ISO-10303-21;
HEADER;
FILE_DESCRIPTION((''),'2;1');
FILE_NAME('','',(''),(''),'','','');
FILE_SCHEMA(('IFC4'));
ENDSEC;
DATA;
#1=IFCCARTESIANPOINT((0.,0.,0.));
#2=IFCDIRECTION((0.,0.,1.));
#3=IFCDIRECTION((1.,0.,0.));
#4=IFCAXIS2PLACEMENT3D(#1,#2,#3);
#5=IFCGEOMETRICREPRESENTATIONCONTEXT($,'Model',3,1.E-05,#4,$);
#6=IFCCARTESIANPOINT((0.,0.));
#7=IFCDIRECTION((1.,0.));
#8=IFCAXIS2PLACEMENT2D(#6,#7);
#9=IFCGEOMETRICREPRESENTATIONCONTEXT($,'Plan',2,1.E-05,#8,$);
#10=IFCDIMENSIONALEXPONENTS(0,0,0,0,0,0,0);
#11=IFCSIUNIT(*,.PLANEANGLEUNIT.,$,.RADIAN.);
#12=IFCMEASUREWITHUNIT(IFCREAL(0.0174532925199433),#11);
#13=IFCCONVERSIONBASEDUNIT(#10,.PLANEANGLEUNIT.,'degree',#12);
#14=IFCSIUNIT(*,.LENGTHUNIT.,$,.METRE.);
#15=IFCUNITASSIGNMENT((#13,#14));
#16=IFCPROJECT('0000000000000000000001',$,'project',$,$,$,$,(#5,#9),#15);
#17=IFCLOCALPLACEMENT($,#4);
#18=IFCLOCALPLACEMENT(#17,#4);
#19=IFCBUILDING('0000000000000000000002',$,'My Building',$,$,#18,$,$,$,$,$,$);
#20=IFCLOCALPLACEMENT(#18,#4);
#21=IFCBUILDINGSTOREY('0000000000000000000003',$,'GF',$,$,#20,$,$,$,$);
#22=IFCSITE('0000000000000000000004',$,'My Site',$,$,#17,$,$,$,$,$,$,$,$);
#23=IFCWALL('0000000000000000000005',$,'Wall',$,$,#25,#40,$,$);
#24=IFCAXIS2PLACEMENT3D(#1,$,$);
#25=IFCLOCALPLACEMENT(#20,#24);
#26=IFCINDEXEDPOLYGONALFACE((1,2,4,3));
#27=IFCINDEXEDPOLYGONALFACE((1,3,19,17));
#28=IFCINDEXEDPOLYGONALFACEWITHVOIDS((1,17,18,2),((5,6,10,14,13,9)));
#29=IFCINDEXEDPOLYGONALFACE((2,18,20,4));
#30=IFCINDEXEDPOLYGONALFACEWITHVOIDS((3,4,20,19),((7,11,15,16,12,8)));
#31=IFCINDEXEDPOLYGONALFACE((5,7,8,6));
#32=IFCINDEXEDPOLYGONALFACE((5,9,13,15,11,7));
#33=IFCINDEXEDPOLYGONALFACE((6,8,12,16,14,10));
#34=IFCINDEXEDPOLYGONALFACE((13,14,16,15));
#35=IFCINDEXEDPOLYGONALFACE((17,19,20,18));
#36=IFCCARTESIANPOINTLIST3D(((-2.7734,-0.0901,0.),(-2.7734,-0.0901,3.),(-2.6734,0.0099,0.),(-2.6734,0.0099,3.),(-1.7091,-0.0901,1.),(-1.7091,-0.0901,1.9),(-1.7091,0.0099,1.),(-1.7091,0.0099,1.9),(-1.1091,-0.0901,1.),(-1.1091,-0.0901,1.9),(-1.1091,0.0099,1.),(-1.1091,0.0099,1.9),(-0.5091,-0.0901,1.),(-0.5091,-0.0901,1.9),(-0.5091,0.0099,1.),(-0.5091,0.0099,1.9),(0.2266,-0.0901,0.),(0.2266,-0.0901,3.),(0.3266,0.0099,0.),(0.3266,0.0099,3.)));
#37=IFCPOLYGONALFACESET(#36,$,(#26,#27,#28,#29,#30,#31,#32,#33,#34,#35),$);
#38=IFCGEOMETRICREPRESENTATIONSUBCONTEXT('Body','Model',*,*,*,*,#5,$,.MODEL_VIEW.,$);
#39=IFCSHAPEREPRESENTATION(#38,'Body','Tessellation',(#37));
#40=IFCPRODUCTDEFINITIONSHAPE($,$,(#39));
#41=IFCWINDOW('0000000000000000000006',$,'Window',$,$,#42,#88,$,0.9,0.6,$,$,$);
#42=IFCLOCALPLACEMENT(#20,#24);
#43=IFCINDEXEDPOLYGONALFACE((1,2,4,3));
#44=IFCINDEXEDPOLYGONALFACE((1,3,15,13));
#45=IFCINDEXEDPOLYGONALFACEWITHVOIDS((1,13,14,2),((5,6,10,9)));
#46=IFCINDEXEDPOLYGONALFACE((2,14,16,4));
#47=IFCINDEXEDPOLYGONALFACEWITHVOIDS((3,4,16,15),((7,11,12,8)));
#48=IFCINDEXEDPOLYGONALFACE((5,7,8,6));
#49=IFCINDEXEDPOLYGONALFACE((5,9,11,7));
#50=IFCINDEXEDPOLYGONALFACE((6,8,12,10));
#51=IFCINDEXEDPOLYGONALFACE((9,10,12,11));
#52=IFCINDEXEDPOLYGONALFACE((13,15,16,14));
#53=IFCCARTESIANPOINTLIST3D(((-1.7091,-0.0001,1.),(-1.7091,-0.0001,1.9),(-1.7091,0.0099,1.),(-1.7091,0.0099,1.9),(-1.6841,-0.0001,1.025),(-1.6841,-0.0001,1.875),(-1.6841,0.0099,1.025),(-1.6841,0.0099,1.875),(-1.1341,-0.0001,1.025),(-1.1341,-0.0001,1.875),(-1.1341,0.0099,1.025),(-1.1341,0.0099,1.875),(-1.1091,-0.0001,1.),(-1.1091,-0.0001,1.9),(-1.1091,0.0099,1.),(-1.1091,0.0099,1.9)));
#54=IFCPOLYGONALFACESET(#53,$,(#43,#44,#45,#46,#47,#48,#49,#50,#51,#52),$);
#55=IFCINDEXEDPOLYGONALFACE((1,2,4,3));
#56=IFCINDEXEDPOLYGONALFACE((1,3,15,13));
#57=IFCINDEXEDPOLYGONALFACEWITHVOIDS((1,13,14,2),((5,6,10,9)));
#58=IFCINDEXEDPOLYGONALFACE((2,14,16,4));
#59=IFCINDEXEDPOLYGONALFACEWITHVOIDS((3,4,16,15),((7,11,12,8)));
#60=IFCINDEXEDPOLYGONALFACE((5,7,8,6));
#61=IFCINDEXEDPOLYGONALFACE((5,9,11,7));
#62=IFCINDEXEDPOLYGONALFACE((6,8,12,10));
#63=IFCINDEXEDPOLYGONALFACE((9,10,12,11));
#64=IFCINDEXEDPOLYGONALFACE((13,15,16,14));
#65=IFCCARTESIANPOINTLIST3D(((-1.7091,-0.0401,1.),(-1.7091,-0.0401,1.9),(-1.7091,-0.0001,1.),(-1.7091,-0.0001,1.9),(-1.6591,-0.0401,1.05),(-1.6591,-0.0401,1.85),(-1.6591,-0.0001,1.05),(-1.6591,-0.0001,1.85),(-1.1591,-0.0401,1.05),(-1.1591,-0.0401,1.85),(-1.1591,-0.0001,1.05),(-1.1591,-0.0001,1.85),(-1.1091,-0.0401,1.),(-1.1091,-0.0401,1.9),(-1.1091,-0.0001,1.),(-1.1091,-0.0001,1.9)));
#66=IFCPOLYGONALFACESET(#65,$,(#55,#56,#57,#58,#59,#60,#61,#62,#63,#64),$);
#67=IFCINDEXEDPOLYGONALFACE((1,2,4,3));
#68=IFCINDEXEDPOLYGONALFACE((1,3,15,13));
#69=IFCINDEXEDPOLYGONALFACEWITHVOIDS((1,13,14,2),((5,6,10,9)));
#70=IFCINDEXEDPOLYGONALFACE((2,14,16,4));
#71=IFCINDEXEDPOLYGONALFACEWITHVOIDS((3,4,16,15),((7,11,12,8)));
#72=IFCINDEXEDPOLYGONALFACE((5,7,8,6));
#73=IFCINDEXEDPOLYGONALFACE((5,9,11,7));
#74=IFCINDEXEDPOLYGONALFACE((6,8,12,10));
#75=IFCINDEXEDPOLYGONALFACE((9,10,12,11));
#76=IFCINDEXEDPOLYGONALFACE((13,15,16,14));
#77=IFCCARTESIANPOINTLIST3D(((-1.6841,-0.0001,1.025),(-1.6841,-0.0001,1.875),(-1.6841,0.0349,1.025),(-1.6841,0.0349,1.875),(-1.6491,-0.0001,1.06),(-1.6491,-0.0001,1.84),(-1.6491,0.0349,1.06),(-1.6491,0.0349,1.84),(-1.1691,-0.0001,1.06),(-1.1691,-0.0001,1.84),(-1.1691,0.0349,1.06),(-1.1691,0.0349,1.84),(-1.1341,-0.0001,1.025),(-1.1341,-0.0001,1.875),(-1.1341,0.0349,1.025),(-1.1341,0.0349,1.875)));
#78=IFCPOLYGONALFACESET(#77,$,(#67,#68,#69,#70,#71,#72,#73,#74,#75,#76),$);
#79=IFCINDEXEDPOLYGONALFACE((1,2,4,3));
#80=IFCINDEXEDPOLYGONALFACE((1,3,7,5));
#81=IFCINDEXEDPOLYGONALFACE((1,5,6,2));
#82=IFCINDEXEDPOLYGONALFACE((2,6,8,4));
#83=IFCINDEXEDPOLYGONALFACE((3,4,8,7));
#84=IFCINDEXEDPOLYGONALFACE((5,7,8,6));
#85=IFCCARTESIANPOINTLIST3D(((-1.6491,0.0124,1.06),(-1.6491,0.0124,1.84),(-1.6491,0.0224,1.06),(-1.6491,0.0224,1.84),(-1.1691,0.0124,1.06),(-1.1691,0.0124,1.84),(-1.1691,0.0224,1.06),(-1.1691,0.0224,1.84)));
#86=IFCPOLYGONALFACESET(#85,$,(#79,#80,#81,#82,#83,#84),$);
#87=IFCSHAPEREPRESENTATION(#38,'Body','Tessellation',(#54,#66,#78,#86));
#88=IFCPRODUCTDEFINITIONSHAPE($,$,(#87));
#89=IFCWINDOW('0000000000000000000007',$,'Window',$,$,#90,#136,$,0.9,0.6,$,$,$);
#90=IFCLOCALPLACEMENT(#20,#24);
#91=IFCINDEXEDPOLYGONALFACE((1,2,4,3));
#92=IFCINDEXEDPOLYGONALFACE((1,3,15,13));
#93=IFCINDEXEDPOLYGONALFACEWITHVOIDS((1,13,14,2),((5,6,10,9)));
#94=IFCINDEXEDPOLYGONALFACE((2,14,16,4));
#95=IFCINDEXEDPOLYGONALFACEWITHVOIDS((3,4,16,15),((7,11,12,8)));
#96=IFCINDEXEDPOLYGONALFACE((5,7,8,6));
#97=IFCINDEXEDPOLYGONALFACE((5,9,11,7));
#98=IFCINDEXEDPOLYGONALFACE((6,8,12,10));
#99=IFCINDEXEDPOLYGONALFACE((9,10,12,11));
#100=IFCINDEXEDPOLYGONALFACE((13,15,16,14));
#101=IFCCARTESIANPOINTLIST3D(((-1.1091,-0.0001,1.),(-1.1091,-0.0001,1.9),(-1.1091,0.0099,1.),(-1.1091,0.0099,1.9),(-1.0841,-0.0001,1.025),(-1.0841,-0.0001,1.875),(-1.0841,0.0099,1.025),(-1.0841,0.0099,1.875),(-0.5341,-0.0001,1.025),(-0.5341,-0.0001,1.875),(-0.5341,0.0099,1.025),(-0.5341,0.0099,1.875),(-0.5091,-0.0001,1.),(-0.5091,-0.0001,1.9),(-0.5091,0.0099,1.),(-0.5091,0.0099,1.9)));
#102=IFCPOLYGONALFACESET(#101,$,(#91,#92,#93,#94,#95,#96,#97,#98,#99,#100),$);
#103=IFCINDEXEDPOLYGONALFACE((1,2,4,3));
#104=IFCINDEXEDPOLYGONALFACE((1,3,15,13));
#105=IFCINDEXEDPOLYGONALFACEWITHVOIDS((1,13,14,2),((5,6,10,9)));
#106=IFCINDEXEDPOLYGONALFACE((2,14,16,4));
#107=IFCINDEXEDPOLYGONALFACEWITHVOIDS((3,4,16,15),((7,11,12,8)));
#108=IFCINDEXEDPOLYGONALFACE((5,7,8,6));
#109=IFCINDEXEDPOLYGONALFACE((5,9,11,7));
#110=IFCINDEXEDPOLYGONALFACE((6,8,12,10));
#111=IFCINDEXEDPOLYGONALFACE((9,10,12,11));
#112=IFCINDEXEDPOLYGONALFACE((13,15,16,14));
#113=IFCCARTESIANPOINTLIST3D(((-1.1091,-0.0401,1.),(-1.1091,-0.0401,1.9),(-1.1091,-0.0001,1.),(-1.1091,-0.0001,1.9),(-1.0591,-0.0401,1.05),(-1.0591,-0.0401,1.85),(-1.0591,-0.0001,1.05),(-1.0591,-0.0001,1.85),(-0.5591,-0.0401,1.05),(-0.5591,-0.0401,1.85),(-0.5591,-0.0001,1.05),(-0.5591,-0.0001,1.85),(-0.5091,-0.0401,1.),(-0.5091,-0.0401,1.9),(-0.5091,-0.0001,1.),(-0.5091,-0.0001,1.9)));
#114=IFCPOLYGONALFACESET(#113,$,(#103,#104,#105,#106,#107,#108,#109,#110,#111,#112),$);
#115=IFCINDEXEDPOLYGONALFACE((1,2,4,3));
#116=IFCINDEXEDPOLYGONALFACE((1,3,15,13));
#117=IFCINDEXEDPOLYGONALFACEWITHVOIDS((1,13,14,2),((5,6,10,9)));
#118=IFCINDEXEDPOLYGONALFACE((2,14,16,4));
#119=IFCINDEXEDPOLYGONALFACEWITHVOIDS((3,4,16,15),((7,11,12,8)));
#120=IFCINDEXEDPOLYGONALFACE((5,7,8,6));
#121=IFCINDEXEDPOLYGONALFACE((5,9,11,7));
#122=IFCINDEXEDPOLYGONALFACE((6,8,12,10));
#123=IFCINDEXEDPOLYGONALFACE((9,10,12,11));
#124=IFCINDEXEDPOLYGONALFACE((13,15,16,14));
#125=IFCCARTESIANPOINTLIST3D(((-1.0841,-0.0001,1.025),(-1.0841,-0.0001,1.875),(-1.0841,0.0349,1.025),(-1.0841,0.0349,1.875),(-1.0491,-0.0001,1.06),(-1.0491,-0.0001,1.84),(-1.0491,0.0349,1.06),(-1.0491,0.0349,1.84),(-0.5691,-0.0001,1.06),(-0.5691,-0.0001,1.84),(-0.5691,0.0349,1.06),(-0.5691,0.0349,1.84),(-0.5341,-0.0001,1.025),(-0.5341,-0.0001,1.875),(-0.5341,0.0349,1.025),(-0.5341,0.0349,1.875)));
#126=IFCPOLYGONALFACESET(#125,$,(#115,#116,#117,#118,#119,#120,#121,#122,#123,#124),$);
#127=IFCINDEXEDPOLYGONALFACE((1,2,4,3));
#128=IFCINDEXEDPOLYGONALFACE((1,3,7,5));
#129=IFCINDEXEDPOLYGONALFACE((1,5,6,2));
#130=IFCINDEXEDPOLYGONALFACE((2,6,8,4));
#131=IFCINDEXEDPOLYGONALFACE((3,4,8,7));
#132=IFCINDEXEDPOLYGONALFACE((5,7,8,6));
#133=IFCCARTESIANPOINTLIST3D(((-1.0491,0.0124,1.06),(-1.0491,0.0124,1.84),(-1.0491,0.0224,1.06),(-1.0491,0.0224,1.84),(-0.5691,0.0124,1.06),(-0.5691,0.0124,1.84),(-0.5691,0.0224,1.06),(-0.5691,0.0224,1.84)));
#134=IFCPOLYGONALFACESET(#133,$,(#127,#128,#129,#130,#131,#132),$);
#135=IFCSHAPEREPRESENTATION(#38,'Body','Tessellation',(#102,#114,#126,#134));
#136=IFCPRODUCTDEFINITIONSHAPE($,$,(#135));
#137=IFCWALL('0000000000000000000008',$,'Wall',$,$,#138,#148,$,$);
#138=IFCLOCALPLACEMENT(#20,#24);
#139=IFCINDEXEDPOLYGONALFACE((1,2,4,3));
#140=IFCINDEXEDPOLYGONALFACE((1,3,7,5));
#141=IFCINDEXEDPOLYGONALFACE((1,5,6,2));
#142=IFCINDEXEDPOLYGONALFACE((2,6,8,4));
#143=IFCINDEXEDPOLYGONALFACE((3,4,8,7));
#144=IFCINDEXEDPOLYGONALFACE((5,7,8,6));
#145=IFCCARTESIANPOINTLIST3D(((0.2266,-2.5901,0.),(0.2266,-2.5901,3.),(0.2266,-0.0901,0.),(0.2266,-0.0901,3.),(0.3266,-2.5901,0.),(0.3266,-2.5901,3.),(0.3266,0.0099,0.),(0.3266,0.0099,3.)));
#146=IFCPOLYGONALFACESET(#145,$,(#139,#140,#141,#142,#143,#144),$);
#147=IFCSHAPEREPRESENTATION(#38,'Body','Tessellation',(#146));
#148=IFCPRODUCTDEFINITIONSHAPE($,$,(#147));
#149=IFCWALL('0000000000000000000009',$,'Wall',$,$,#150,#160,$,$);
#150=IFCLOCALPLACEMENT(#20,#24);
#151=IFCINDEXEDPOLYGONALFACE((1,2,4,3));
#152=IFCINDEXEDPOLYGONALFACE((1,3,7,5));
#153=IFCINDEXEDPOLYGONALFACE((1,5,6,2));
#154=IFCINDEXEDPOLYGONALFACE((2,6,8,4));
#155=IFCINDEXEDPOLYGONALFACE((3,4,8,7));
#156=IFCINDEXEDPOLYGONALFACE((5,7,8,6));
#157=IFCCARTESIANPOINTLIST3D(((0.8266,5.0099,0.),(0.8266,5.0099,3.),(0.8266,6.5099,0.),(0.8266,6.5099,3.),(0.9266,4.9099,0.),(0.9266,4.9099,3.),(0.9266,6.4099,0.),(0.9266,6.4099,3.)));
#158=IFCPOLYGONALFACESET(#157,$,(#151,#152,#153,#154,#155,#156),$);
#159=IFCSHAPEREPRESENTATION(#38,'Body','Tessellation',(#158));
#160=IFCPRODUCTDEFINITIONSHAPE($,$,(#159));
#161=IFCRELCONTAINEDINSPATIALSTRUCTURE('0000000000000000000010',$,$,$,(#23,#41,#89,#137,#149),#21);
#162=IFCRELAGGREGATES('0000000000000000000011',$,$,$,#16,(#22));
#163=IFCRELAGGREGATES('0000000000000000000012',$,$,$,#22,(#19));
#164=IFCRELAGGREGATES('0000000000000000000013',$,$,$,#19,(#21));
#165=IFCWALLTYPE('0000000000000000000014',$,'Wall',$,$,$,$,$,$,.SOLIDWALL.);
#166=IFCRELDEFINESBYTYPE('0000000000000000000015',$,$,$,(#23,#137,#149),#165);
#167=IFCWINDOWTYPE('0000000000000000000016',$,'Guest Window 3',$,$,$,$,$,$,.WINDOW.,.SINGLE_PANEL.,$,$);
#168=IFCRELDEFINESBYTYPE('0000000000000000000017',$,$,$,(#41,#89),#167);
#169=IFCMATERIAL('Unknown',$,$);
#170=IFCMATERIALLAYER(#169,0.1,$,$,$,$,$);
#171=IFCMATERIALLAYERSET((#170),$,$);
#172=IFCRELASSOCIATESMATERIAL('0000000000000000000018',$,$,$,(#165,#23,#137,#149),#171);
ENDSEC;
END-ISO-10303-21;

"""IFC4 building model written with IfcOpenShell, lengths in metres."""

from ifc_helpers import new_model, entity, si_unit, converted_unit, frame, origin_with_axes, origin_2d_with_axis, place, context, subcontext, project, spatial, line, indexed_curve, outline, extrude, shape, source, transform, mapped, material, layer, layer_set, layer_usage, type_object, type_shapes, element, fill, save


model = new_model("IFC4")

# Units and contexts
model_context = context("Model", 3, precision=1e-05, world=origin_with_axes())
plan_context = context("Plan", 2, precision=1e-05, world=origin_2d_with_axis())
body_context_1 = subcontext(model_context, "Body", "Model", "MODEL_VIEW")
body_context_2 = subcontext(plan_context, "Body", "Plan", "PLAN_VIEW")
ifc_project = project(units=[converted_unit("PLANEANGLEUNIT", "degree", entity("IfcReal", 0.0174532925199433), si_unit("PLANEANGLEUNIT", "RADIAN"), dimensions=[0, 0, 0, 0, 0, 0, 0]), si_unit("LENGTHUNIT", "METRE")], contexts=[model_context, plan_context])

# Site, building, storey
site_placement = place(None, origin_with_axes())
site = spatial("IfcSite", under=ifc_project, at=site_placement, Name="My Site")
building_placement = place(site_placement, origin_with_axes())
building = spatial("IfcBuilding", under=site, at=building_placement, Name="My Building")
storey_placement = place(building_placement, origin_with_axes())
storey = spatial("IfcBuildingStorey", under=building, at=storey_placement, Name="GF")

# Shared definitions
ifc_material = material(Name="Unknown")

# Shared definitions
ifc_layer_1 = layer(ifc_material, 0.1)
ifc_layer_set_1 = layer_set([ifc_layer_1])
wall_type = type_object("IfcWallType", Name="Wall", PredefinedType="SOLIDWALL", material=ifc_layer_set_1)

# Wall, openings, windows
ifc_layer_usage_1 = layer_usage(ifc_layer_set_1, "AXIS2", "POSITIVE", 0.0)
wall_1_placement = place(storey_placement, frame((-2.7734, -0.0901, 0.0), z_axis=(0.0, 0.0, 1.0), x_axis=(1.0, 0.0, 0.0)))
wall_1 = element("IfcWall", 1, at=wall_1_placement, inside=storey, type_object=wall_type, material=ifc_layer_usage_1, Name="Wall", context=body_context_1, shape_type="SweptSolid", body=[
    extrude(outline(indexed_curve([(0.0, 0.0), (0.1, 0.1), (3.1, 0.1), (3.0, 0.0)], segments=[line(1, 2, 3, 4, 1)])), origin_with_axes(), (0.0, 0.0, 1.0), 3.0),
])
shared_shape_1 = source(origin_with_axes(), body_context_1, "Body", "SweptSolid", [
    extrude(outline(indexed_curve([(0.0, 0.0), (0.6, 0.0), (0.6, 0.9), (0.0, 0.9)], segments=[line(1, 2, 3, 4, 1)])), frame((0.0, -0.6, 0.0), z_axis=(0.0, -1.0, 0.0), x_axis=(1.0, 0.0, 0.0)), (0.0, 0.0, -1.0), 1.2),
])
opening_1_placement = place(wall_1_placement, frame((1.0643, 0.0, 1.0), z_axis=(0.0, 0.0, 1.0), x_axis=(1.0, 0.0, 0.0)))
opening_1 = element("IfcOpeningElement", 2, at=opening_1_placement, cuts=wall_1, PredefinedType="OPENING", context=body_context_1, shape_type="MappedRepresentation", body=[
    mapped(shared_shape_1, transform((0.0, 0.0, 0.0), x_axis=(1.0, 0.0, 0.0), y_axis=(0.0, 1.0, 0.0), z_axis=(0.0, 0.0, 1.0), scale=1.0)),
])
opening_2_placement = place(wall_1_placement, frame((1.6643, 0.0, 1.0), z_axis=(0.0, 0.0, 1.0), x_axis=(1.0, 0.0, 0.0)))
opening_2 = element("IfcOpeningElement", 3, at=opening_2_placement, cuts=wall_1, PredefinedType="OPENING", context=body_context_1, shape_type="MappedRepresentation", body=[
    mapped(shared_shape_1, transform((0.0, 0.0, 0.0), x_axis=(1.0, 0.0, 0.0), y_axis=(0.0, 1.0, 0.0), z_axis=(0.0, 0.0, 1.0), scale=1.0)),
])
window_type_1 = type_object("IfcWindowType", Name="Guest Window 3", PartitioningType="SINGLE_PANEL", PredefinedType="WINDOW")
shared_shape_2 = source(origin_with_axes(), body_context_1, "Body", "SweptSolid", [
    extrude(outline(indexed_curve([(0.0, 0.0), (0.6, 0.0), (0.6, 0.9), (0.0, 0.9)], segments=[line(1, 2, 3, 4, 1)]), holes=[indexed_curve([(0.025, 0.025), (0.575, 0.025), (0.575, 0.875), (0.025, 0.875)], segments=[line(1, 2, 3, 4, 1)])]), frame((0.0, 0.09, 0.0), z_axis=(0.0, -1.0, 0.0), x_axis=(1.0, 0.0, 0.0)), (0.0, 0.0, -1.0), 0.01),
    extrude(outline(indexed_curve([(0.0, 0.0), (0.6, 0.0), (0.6, 0.9), (0.0, 0.9)], segments=[line(1, 2, 3, 4, 1)]), holes=[indexed_curve([(0.05, 0.05), (0.55, 0.05), (0.55, 0.85), (0.05, 0.85)], segments=[line(1, 2, 3, 4, 1)])]), frame((0.0, 0.05, 0.0), z_axis=(0.0, -1.0, 0.0), x_axis=(1.0, 0.0, 0.0)), (0.0, 0.0, -1.0), 0.04),
    extrude(outline(indexed_curve([(0.0, 0.0), (0.55, 0.0), (0.55, 0.85), (0.0, 0.85)], segments=[line(1, 2, 3, 4, 1)]), holes=[indexed_curve([(0.035, 0.035), (0.515, 0.035), (0.515, 0.815), (0.035, 0.815)], segments=[line(1, 2, 3, 4, 1)])]), frame((0.025, 0.09, 0.025), z_axis=(0.0, -1.0, 0.0), x_axis=(1.0, 0.0, 0.0)), (0.0, 0.0, -1.0), 0.035),
    extrude(outline(indexed_curve([(0.035, 0.035), (0.515, 0.035), (0.515, 0.815), (0.035, 0.815)], segments=[line(1, 2, 3, 4, 1)])), frame((0.025, 0.1025, 0.025), z_axis=(0.0, -1.0, 0.0), x_axis=(1.0, 0.0, 0.0)), (0.0, 0.0, -1.0), 0.01),
])
shared_shape_3 = source(origin_with_axes(), body_context_2, "Body", "Curve2D", [
    entity("IfcIndexedPolyCurve", entity("IfcCartesianPointList2D", [[0.05, 0.05], [0.55, 0.05]])),
    entity("IfcIndexedPolyCurve", entity("IfcCartesianPointList2D", [[0.0, 0.1], [0.025, 0.1], [0.025, 0.09], [0.05, 0.09], [0.05, 0.05], [0.0, 0.05]]), [entity("IfcLineIndex", [1, 2, 3, 4, 5, 6, 1])]),
    entity("IfcIndexedPolyCurve", entity("IfcCartesianPointList2D", [[0.6, 0.1], [0.575, 0.1], [0.575, 0.09], [0.55, 0.09], [0.55, 0.05], [0.6, 0.05]]), [entity("IfcLineIndex", [1, 2, 3, 4, 5, 6, 1])]),
    entity("IfcIndexedPolyCurve", entity("IfcCartesianPointList2D", [[0.025, 0.09], [0.06, 0.09], [0.06, 0.125], [0.025, 0.125]]), [entity("IfcLineIndex", [1, 2, 3, 4, 1])]),
    entity("IfcIndexedPolyCurve", entity("IfcCartesianPointList2D", [[0.575, 0.09], [0.54, 0.09], [0.54, 0.125], [0.575, 0.125]]), [entity("IfcLineIndex", [1, 2, 3, 4, 1])]),
    entity("IfcIndexedPolyCurve", entity("IfcCartesianPointList2D", [[0.06, 0.09], [0.54, 0.09]])),
    entity("IfcIndexedPolyCurve", entity("IfcCartesianPointList2D", [[0.06, 0.125], [0.54, 0.125]])),
    entity("IfcIndexedPolyCurve", entity("IfcCartesianPointList2D", [[0.06, 0.1075], [0.54, 0.1075]])),
])
type_shapes(window_type_1, [shared_shape_2, shared_shape_3])
window_1_placement = place(opening_1_placement, origin_with_axes())
window_1 = element("IfcWindow", 4, at=window_1_placement, inside=storey, type_object=window_type_1, Name="Window", OverallHeight=0.9, OverallWidth=0.6, shapes=[
    shape(body_context_1, "Body", "MappedRepresentation", [mapped(shared_shape_2, transform((0.0, 0.0, 0.0), x_axis=(1.0, 0.0, 0.0), y_axis=(0.0, 1.0, 0.0), z_axis=(0.0, 0.0, 1.0), scale=1.0))]),
    shape(body_context_2, "Body", "MappedRepresentation", [mapped(shared_shape_3, transform((0.0, 0.0, 0.0), x_axis=(1.0, 0.0, 0.0), y_axis=(0.0, 1.0, 0.0), z_axis=(0.0, 0.0, 1.0), scale=1.0))]),
])
fill(opening_1, window_1)
window_2_placement = place(opening_2_placement, origin_with_axes())
window_2 = element("IfcWindow", 5, at=window_2_placement, inside=storey, type_object=window_type_1, Name="Window", OverallHeight=0.9, OverallWidth=0.6, shapes=[
    shape(body_context_1, "Body", "MappedRepresentation", [mapped(shared_shape_2, transform((0.0, 0.0, 0.0), x_axis=(1.0, 0.0, 0.0), y_axis=(0.0, 1.0, 0.0), z_axis=(0.0, 0.0, 1.0), scale=1.0))]),
    shape(body_context_2, "Body", "MappedRepresentation", [mapped(shared_shape_3, transform((0.0, 0.0, 0.0), x_axis=(1.0, 0.0, 0.0), y_axis=(0.0, 1.0, 0.0), z_axis=(0.0, 0.0, 1.0), scale=1.0))]),
])
fill(opening_2, window_2)

# Walls
ifc_layer_usage_2 = layer_usage(ifc_layer_set_1, "AXIS2", "POSITIVE", 0.0)
wall_2_placement = place(storey_placement, frame((0.2266, -0.0901, 0.0), z_axis=(0.0, 0.0, 1.0), x_axis=(0.0, -1.0, 0.0)))
element("IfcWall", 6, at=wall_2_placement, inside=storey, type_object=wall_type, material=ifc_layer_usage_2, Name="Wall", context=body_context_1, shape_type="SweptSolid", body=[
    extrude(outline(indexed_curve([(0.0, 0.0), (-0.1, 0.1), (2.5, 0.1), (2.5, 0.0)], segments=[line(1, 2, 3, 4, 1)])), origin_with_axes(), (0.0, 0.0, 1.0), 3.0),
])
ifc_layer_usage_3 = layer_usage(ifc_layer_set_1, "AXIS2", "POSITIVE", 0.0)
wall_3_placement = place(storey_placement, frame((0.8266, 6.5099, 0.0), z_axis=(0.0, 0.0, 1.0), x_axis=(0.0, -1.0, 0.0)))
element("IfcWall", 7, at=wall_3_placement, inside=storey, type_object=wall_type, material=ifc_layer_usage_3, Name="Wall", context=body_context_1, shape_type="SweptSolid", body=[
    extrude(outline(indexed_curve([(0.0, 0.0), (0.1, 0.1), (1.6, 0.1), (1.5, 0.0)], segments=[line(1, 2, 3, 4, 1)])), origin_with_axes(), (0.0, 0.0, 1.0), 3.0),
])

save(model, "model.ifc")
